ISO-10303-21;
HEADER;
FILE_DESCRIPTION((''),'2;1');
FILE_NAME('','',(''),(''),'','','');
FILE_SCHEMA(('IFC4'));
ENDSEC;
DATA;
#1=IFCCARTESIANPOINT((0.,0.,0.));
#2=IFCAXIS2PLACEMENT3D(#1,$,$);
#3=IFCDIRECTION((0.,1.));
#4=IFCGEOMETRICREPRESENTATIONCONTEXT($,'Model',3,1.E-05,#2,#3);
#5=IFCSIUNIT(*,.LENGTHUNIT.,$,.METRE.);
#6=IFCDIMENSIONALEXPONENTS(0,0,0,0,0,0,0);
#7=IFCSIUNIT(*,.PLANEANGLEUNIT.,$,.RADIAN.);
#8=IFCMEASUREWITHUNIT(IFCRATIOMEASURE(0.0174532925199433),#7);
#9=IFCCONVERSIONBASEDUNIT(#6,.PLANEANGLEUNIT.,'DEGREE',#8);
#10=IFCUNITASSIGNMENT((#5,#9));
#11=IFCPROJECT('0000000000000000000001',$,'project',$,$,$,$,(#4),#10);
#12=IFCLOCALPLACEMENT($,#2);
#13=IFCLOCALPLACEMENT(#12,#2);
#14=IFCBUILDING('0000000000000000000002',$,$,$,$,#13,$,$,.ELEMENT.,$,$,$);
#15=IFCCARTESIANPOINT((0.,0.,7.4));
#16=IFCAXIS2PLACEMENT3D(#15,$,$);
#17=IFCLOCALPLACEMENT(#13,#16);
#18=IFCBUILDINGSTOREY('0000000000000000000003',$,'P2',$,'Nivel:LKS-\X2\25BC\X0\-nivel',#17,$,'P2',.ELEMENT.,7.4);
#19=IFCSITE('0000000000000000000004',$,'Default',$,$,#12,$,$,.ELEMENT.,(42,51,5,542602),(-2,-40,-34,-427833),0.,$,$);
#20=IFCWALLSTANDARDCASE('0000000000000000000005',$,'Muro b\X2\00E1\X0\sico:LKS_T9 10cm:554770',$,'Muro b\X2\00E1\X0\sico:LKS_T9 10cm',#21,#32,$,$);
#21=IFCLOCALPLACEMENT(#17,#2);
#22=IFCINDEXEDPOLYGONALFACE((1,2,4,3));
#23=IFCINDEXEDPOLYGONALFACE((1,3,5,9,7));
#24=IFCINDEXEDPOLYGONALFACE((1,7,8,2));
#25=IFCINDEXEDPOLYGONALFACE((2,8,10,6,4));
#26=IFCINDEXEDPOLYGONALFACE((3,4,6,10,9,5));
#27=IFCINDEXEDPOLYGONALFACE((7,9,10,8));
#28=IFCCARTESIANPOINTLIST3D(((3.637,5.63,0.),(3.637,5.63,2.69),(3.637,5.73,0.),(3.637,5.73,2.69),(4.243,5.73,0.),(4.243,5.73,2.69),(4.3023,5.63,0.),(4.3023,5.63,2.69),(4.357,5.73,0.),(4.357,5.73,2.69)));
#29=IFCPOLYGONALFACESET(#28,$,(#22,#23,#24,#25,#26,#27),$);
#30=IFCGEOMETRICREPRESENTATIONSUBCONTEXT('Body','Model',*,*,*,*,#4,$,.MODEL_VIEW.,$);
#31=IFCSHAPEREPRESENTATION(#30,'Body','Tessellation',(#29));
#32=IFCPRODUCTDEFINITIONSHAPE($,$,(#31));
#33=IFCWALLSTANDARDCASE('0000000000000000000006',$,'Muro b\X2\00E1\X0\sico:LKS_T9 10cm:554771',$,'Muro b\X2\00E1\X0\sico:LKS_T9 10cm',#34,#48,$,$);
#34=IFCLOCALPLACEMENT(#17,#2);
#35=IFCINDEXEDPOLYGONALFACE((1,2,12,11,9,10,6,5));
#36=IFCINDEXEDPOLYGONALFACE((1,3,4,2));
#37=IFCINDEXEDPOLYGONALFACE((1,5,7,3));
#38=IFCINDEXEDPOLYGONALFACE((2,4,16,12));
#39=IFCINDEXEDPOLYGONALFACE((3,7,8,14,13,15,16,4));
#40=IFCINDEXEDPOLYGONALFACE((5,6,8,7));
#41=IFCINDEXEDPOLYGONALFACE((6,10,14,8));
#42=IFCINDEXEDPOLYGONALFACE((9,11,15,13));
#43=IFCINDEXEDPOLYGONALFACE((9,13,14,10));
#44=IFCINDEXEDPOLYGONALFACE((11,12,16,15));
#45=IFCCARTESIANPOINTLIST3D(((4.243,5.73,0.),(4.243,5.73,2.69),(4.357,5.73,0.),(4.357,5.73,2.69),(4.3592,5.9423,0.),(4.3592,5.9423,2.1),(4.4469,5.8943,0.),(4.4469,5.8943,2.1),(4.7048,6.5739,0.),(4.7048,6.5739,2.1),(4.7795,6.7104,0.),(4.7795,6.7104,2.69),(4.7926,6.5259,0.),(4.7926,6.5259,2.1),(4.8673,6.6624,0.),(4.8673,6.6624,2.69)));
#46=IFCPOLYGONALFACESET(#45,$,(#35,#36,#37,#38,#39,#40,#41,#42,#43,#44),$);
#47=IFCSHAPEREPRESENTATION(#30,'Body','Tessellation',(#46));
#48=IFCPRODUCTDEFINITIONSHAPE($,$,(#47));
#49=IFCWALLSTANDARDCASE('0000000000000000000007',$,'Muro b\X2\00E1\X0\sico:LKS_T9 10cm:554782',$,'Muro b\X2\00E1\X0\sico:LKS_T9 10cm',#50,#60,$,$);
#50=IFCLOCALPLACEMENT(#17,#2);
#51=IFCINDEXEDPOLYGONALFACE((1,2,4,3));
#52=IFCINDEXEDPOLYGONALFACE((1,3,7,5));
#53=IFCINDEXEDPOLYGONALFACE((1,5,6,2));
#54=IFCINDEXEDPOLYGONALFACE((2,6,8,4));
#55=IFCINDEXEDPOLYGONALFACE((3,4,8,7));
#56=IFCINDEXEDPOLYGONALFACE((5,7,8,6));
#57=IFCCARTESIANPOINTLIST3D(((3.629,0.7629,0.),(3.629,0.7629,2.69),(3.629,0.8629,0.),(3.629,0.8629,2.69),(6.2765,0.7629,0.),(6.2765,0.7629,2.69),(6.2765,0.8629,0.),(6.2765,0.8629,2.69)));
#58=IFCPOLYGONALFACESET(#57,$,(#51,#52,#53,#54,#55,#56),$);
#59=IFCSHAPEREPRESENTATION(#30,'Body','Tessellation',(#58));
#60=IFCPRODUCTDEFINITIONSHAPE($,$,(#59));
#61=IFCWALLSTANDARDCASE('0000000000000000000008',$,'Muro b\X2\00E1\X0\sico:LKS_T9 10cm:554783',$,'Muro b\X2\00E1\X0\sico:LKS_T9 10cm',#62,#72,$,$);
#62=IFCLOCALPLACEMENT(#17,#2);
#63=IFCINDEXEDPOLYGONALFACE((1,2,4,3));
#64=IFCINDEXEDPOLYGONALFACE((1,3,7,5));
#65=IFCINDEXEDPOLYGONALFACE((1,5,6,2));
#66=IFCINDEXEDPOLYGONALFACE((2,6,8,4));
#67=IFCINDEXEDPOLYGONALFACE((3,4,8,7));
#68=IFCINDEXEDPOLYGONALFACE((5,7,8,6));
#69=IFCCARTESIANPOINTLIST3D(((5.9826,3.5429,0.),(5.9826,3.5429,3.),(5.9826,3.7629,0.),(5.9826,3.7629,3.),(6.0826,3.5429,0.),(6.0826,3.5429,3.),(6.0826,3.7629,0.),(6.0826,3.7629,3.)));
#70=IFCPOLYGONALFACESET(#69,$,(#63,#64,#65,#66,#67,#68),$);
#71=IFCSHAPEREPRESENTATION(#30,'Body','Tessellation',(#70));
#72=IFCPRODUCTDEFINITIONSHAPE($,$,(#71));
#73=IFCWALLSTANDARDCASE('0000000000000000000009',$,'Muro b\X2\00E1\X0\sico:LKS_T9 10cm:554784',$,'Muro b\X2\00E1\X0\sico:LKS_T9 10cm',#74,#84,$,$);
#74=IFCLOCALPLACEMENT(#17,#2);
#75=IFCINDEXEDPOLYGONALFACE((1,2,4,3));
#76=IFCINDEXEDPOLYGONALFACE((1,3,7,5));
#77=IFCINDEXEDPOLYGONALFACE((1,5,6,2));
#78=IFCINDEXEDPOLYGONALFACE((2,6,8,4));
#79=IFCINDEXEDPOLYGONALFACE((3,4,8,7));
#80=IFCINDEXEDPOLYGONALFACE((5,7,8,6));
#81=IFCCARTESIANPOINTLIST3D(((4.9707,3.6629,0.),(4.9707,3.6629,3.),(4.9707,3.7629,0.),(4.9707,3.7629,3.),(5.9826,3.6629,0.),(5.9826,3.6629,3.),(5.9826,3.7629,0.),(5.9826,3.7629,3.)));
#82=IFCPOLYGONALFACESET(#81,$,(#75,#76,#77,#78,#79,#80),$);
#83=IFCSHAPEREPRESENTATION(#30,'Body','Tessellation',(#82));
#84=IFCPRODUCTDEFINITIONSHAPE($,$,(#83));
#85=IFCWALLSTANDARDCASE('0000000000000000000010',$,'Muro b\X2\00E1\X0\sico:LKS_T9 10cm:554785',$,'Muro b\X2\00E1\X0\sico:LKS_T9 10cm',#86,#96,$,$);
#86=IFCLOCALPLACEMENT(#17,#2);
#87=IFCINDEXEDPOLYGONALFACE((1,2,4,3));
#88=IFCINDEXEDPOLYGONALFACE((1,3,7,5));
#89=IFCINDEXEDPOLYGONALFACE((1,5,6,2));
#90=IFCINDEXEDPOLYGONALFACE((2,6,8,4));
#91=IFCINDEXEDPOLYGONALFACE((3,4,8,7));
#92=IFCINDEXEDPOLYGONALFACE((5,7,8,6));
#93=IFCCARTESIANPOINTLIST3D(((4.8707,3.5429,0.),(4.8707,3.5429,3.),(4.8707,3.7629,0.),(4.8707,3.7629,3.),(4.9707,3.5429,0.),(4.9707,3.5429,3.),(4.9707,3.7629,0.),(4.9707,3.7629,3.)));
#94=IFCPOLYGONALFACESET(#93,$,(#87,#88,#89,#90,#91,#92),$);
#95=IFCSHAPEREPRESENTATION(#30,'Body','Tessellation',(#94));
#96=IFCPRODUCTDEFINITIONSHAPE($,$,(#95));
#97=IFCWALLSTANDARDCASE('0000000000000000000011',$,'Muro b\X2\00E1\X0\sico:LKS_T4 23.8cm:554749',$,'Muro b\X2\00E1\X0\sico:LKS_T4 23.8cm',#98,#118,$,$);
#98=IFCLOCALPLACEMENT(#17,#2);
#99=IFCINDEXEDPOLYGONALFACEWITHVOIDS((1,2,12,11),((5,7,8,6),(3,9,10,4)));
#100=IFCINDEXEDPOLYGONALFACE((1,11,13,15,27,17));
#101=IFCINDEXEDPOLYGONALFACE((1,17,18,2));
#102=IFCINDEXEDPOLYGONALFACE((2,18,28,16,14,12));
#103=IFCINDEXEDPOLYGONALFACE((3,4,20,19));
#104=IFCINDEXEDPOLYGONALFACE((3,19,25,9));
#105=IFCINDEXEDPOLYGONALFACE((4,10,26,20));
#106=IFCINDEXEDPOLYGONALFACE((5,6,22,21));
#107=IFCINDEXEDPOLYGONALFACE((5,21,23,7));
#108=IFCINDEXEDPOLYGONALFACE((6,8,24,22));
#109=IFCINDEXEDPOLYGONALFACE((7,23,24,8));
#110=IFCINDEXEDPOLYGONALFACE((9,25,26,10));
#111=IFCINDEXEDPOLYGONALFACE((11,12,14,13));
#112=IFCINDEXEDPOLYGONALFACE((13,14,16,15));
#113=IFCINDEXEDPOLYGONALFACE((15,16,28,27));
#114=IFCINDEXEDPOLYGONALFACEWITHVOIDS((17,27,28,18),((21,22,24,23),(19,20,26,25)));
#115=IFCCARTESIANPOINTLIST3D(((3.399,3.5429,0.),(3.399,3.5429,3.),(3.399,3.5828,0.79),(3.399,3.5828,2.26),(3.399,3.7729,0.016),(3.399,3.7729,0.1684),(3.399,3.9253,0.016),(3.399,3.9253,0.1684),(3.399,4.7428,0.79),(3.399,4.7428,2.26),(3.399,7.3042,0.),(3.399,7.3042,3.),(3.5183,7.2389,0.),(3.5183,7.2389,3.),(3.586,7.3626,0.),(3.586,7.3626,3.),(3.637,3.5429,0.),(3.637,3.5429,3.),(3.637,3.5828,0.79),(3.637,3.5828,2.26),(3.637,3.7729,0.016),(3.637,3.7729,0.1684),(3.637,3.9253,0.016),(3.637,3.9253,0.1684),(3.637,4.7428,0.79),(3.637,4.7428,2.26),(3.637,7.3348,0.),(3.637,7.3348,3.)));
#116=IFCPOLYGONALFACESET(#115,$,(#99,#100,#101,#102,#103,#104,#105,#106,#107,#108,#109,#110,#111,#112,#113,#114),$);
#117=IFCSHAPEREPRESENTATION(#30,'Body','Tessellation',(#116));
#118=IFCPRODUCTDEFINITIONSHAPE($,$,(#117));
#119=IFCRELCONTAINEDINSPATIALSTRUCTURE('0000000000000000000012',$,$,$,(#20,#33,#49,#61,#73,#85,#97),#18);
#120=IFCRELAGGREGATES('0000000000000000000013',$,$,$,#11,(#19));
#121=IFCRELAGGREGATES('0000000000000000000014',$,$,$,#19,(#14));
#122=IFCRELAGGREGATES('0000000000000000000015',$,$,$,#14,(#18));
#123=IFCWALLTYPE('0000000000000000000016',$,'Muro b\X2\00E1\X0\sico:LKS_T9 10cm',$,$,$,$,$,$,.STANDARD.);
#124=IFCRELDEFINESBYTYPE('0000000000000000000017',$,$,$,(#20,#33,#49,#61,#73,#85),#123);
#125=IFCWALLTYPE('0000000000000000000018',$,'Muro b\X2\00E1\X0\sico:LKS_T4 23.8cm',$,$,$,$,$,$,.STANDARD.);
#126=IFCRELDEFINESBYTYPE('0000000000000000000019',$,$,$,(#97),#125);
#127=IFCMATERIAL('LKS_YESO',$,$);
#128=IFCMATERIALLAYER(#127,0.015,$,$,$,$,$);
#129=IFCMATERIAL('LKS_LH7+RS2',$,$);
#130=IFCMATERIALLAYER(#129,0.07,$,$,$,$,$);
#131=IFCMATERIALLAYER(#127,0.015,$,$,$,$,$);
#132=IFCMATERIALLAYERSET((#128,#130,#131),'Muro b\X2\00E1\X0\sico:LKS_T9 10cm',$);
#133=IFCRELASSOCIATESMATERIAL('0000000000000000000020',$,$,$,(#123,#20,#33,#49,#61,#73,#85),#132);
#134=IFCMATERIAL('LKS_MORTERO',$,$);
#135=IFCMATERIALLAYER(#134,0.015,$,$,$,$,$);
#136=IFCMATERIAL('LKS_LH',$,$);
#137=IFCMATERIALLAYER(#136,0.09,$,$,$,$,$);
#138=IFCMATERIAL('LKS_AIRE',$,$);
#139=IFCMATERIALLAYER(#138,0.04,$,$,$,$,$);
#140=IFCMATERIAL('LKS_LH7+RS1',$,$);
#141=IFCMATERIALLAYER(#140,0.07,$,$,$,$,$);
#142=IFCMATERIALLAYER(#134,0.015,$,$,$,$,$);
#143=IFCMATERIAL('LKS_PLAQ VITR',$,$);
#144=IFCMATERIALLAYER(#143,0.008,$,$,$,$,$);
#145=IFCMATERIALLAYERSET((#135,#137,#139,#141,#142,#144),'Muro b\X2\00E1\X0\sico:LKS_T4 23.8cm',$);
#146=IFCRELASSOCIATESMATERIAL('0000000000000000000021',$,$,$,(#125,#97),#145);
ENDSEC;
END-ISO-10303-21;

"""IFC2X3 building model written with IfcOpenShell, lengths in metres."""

from ifc_helpers import new_model, entity, si_unit, converted_unit, direction, frame, frame_2d, origin, place, context, subcontext, project, spatial, polyline, rectangle, outline, extrude, clip, bounded_halfspace, material, layer, layer_set, layer_usage, type_object, element, save


model = new_model("IFC2X3")

# Units and contexts
model_context = context("Model", 3, precision=1e-05, world=origin(), true_north=direction((0.0, 1.0)))
body_context = subcontext(model_context, "Body", "Model", "MODEL_VIEW")
ifc_project = project(units=[si_unit("LENGTHUNIT", "METRE"), converted_unit("PLANEANGLEUNIT", "DEGREE", entity("IfcRatioMeasure", 0.0174532925199433), si_unit("PLANEANGLEUNIT", "RADIAN"), dimensions=[0, 0, 0, 0, 0, 0, 0])], contexts=[model_context])

# Site, building, storey
site_placement = place(None, origin())
site = spatial("IfcSite", under=ifc_project, at=site_placement, Name="Default", CompositionType="ELEMENT", RefLatitude=(42, 51, 5, 542602), RefLongitude=(-2, -40, -34, -427833), RefElevation=0.0)
building_placement = place(site_placement, origin())
building = spatial("IfcBuilding", under=site, at=building_placement, CompositionType="ELEMENT")
storey_placement = place(building_placement, frame((0.0, 0.0, 7.4)))
storey = spatial("IfcBuildingStorey", under=building, at=storey_placement, Name="P2", ObjectType="Nivel:LKS-▼-nivel", LongName="P2", CompositionType="ELEMENT", Elevation=7.4)

# Shared definitions
ifc_material_1 = material(Name="LKS_MORTERO")
ifc_material_2 = material(Name="LKS_PLAQ VITR")

# Shared definitions
ifc_material_3 = material(Name="LKS_LH")
ifc_material_4 = material(Name="LKS_AIRE")
ifc_material_5 = material(Name="LKS_LH7+RS1")
ifc_material_6 = material(Name="LKS_YESO")

# Shared definitions
ifc_layer_1 = layer(ifc_material_6, 0.015)
ifc_material_7 = material(Name="LKS_LH7+RS2")
ifc_layer_2 = layer(ifc_material_7, 0.07)
ifc_layer_3 = layer(ifc_material_6, 0.015)
ifc_layer_set_1 = layer_set([ifc_layer_1, ifc_layer_2, ifc_layer_3], Name="Muro básico:LKS_T9 10cm")
wall_type_1 = type_object("IfcWallType", Name="Muro básico:LKS_T9 10cm", PredefinedType="STANDARD", material=ifc_layer_set_1)

# Wall
ifc_layer_usage_1 = layer_usage(ifc_layer_set_1, "AXIS2", "NEGATIVE", 0.05)
wall_1_placement = place(storey_placement, frame((3.637, 5.68, 0.0)))
element("IfcWallStandardCase", 1, at=wall_1_placement, inside=storey, type_object=wall_type_1, material=ifc_layer_usage_1, Name="Muro básico:LKS_T9 10cm:554770", ObjectType="Muro básico:LKS_T9 10cm", context=body_context, shape_type="SweptSolid", body=[
    extrude(outline(polyline([(0.6654, -0.05), (0.7201, 0.05), (0.6061, 0.05), (0.0, 0.05), (0.0, -0.05), (0.6654, -0.05)])), origin(), (0.0, 0.0, 1.0), 2.69),
])

# Wall, opening
ifc_layer_usage_2 = layer_usage(ifc_layer_set_1, "AXIS2", "NEGATIVE", 0.05)
wall_2_placement = place(storey_placement, frame((4.2869, 5.706, 0.0), z_axis=(0.0, 0.0, 1.0), x_axis=(0.480022, 0.877256, 0.0)))
wall_2 = element("IfcWallStandardCase", 2, at=wall_2_placement, inside=storey, type_object=wall_type_1, material=ifc_layer_usage_2, Name="Muro básico:LKS_T9 10cm:554771", ObjectType="Muro básico:LKS_T9 10cm", context=body_context, shape_type="SweptSolid", body=[
    extrude(outline(polyline([(0.0547, -0.05), (1.1176, -0.05), (1.1176, 0.05), (0.0, 0.05), (0.0547, -0.05)])), origin(), (0.0, 0.0, 1.0), 2.69),
])
opening_1_placement = place(wall_2_placement, frame((0.962, 0.05, 0.0)))
element("IfcOpeningElement", 3, at=opening_1_placement, cuts=wall_2, ObjectType="Opening", context=body_context, shape_type="SweptSolid", body=[
    extrude(rectangle(XDim=2.1, YDim=0.72, at=frame_2d((1.05, 0.36), x_axis=(1.0, 0.0))), frame((0.0, 0.0, 0.0), z_axis=(0.0, -1.0, 0.0), x_axis=(0.0, 0.0, 1.0)), (0.0, 0.0, 1.0), 0.1),
])

# Walls
ifc_layer_usage_3 = layer_usage(ifc_layer_set_1, "AXIS2", "NEGATIVE", 0.05)
wall_3_placement = place(storey_placement, frame((6.2765, 0.8129, 0.0), z_axis=(0.0, 0.0, 1.0), x_axis=(-1.0, 0.0, 0.0)))
element("IfcWallStandardCase", 4, at=wall_3_placement, inside=storey, type_object=wall_type_1, material=ifc_layer_usage_3, Name="Muro básico:LKS_T9 10cm:554782", ObjectType="Muro básico:LKS_T9 10cm", context=body_context, shape_type="SweptSolid", body=[
    extrude(rectangle(XDim=2.6476, YDim=0.1, at=frame_2d((1.3238, 0.0), x_axis=(-1.0, 0.0))), origin(), (0.0, 0.0, 1.0), 2.69),
])
ifc_layer_usage_4 = layer_usage(ifc_layer_set_1, "AXIS2", "NEGATIVE", 0.05)
wall_4_placement = place(storey_placement, frame((6.0326, 3.5429, 0.0), z_axis=(0.0, 0.0, 1.0), x_axis=(0.0, 1.0, 0.0)))
element("IfcWallStandardCase", 5, at=wall_4_placement, inside=storey, type_object=wall_type_1, material=ifc_layer_usage_4, Name="Muro básico:LKS_T9 10cm:554783", ObjectType="Muro básico:LKS_T9 10cm", context=body_context, shape_type="SweptSolid", body=[
    extrude(rectangle(XDim=0.22, YDim=0.1, at=frame_2d((0.11, 0.0), x_axis=(-1.0, 0.0))), origin(), (0.0, 0.0, 1.0), 3.0),
])
ifc_layer_usage_5 = layer_usage(ifc_layer_set_1, "AXIS2", "NEGATIVE", 0.05)
wall_5_placement = place(storey_placement, frame((5.9826, 3.7129, 0.0), z_axis=(0.0, 0.0, 1.0), x_axis=(-1.0, 0.0, 0.0)))
element("IfcWallStandardCase", 6, at=wall_5_placement, inside=storey, type_object=wall_type_1, material=ifc_layer_usage_5, Name="Muro básico:LKS_T9 10cm:554784", ObjectType="Muro básico:LKS_T9 10cm", context=body_context, shape_type="SweptSolid", body=[
    extrude(rectangle(XDim=1.012, YDim=0.1, at=frame_2d((0.506, 0.0), x_axis=(-1.0, 0.0))), origin(), (0.0, 0.0, 1.0), 3.0),
])
ifc_layer_usage_6 = layer_usage(ifc_layer_set_1, "AXIS2", "NEGATIVE", 0.05)
wall_6_placement = place(storey_placement, frame((4.9207, 3.7629, 0.0), z_axis=(0.0, 0.0, 1.0), x_axis=(0.0, -1.0, 0.0)))
element("IfcWallStandardCase", 7, at=wall_6_placement, inside=storey, type_object=wall_type_1, material=ifc_layer_usage_6, Name="Muro básico:LKS_T9 10cm:554785", ObjectType="Muro básico:LKS_T9 10cm", context=body_context, shape_type="SweptSolid", body=[
    extrude(rectangle(XDim=0.22, YDim=0.1, at=frame_2d((0.11, 0.0), x_axis=(-1.0, 0.0))), origin(), (0.0, 0.0, 1.0), 3.0),
])

# Wall, openings
ifc_layer_4 = layer(ifc_material_1, 0.015)
ifc_layer_5 = layer(ifc_material_3, 0.09)
ifc_layer_6 = layer(ifc_material_4, 0.04)
ifc_layer_7 = layer(ifc_material_5, 0.07)
ifc_layer_8 = layer(ifc_material_1, 0.015)
ifc_layer_9 = layer(ifc_material_2, 0.008)
ifc_layer_set_2 = layer_set([ifc_layer_4, ifc_layer_5, ifc_layer_6, ifc_layer_7, ifc_layer_8, ifc_layer_9], Name="Muro básico:LKS_T4 23.8cm")
ifc_layer_usage_7 = layer_usage(ifc_layer_set_2, "AXIS2", "NEGATIVE", 0.119)
wall_type_2 = type_object("IfcWallType", Name="Muro básico:LKS_T4 23.8cm", PredefinedType="STANDARD", material=ifc_layer_set_2)
wall_7_placement = place(storey_placement, frame((3.518, 7.3348, 0.0), z_axis=(0.0, 0.0, 1.0), x_axis=(0.0, -1.0, 0.0)))
wall_7 = element("IfcWallStandardCase", 8, at=wall_7_placement, inside=storey, type_object=wall_type_2, material=ifc_layer_usage_7, Name="Muro básico:LKS_T4 23.8cm:554749", ObjectType="Muro básico:LKS_T4 23.8cm", context=body_context, shape_type="Clipping", body=[
    clip(clip(extrude(outline(polyline([(0.0, 0.119), (-0.0276, 0.0685), (-0.0279, 0.068), (0.0959, 0.0004), (0.0306, -0.119), (0.0318, -0.119), (3.7919, -0.119), (3.7919, 0.111), (3.7919, 0.119), (1.7048, 0.119), (1.6048, 0.119), (0.0, 0.119)])), origin(), (0.0, 0.0, 1.0), 3.0), bounded_halfspace(frame((0.0959, 0.0004, 0.0), z_axis=(0.479561, 0.877509, 0.0), x_axis=(0.0, 0.0, -1.0)), True, frame((0.0959, 0.0004, 0.0), z_axis=(0.479561, 0.877509, 0.0), x_axis=(0.0, 0.0, -1.0)), polyline([(0.0, 0.0), (0.0, 0.141), (-3.0, 0.141), (-3.0, 0.0), (-2.67, 0.0), (0.0, 0.0)]))), bounded_halfspace(frame((0.0959, 0.0004, 3.0), z_axis=(0.877509, -0.479561, 0.0), x_axis=(0.0, 0.0, -1.0)), True, frame((0.0959, 0.0004, 3.0), z_axis=(0.877509, -0.479561, 0.0), x_axis=(0.0, 0.0, -1.0)), polyline([(0.0, 0.0), (0.0, -0.0791), (0.0, -0.1361), (3.0, -0.1361), (3.0, 0.0), (0.33, 0.0), (0.0, 0.0)]))),
])
opening_2_placement = place(wall_7_placement, origin())
element("IfcOpeningElement", 9, at=opening_2_placement, cuts=wall_7, ObjectType="Opening", context=body_context, shape_type="SweptSolid", body=[
    extrude(rectangle(XDim=0.1524, YDim=0.1524, at=frame_2d((0.0, 0.0), x_axis=(0.0, 1.0))), frame((3.4857, -1.405, 0.0922), z_axis=(0.0, 1.0, 0.0), x_axis=(-1.0, 0.0, 0.0)), (0.0, 0.0, 1.0), 3.048),
])
opening_3_placement = place(wall_7_placement, frame((3.752, 0.119, 0.79)))
element("IfcOpeningElement", 10, at=opening_3_placement, cuts=wall_7, ObjectType="Opening", context=body_context, shape_type="SweptSolid", body=[
    extrude(rectangle(XDim=1.47, YDim=1.16, at=frame_2d((0.735, 0.58), x_axis=(1.0, 0.0))), frame((0.0, 0.0, 0.0), z_axis=(0.0, -1.0, 0.0), x_axis=(0.0, 0.0, 1.0)), (0.0, 0.0, 1.0), 0.238),
])

save(model, "model.ifc")
